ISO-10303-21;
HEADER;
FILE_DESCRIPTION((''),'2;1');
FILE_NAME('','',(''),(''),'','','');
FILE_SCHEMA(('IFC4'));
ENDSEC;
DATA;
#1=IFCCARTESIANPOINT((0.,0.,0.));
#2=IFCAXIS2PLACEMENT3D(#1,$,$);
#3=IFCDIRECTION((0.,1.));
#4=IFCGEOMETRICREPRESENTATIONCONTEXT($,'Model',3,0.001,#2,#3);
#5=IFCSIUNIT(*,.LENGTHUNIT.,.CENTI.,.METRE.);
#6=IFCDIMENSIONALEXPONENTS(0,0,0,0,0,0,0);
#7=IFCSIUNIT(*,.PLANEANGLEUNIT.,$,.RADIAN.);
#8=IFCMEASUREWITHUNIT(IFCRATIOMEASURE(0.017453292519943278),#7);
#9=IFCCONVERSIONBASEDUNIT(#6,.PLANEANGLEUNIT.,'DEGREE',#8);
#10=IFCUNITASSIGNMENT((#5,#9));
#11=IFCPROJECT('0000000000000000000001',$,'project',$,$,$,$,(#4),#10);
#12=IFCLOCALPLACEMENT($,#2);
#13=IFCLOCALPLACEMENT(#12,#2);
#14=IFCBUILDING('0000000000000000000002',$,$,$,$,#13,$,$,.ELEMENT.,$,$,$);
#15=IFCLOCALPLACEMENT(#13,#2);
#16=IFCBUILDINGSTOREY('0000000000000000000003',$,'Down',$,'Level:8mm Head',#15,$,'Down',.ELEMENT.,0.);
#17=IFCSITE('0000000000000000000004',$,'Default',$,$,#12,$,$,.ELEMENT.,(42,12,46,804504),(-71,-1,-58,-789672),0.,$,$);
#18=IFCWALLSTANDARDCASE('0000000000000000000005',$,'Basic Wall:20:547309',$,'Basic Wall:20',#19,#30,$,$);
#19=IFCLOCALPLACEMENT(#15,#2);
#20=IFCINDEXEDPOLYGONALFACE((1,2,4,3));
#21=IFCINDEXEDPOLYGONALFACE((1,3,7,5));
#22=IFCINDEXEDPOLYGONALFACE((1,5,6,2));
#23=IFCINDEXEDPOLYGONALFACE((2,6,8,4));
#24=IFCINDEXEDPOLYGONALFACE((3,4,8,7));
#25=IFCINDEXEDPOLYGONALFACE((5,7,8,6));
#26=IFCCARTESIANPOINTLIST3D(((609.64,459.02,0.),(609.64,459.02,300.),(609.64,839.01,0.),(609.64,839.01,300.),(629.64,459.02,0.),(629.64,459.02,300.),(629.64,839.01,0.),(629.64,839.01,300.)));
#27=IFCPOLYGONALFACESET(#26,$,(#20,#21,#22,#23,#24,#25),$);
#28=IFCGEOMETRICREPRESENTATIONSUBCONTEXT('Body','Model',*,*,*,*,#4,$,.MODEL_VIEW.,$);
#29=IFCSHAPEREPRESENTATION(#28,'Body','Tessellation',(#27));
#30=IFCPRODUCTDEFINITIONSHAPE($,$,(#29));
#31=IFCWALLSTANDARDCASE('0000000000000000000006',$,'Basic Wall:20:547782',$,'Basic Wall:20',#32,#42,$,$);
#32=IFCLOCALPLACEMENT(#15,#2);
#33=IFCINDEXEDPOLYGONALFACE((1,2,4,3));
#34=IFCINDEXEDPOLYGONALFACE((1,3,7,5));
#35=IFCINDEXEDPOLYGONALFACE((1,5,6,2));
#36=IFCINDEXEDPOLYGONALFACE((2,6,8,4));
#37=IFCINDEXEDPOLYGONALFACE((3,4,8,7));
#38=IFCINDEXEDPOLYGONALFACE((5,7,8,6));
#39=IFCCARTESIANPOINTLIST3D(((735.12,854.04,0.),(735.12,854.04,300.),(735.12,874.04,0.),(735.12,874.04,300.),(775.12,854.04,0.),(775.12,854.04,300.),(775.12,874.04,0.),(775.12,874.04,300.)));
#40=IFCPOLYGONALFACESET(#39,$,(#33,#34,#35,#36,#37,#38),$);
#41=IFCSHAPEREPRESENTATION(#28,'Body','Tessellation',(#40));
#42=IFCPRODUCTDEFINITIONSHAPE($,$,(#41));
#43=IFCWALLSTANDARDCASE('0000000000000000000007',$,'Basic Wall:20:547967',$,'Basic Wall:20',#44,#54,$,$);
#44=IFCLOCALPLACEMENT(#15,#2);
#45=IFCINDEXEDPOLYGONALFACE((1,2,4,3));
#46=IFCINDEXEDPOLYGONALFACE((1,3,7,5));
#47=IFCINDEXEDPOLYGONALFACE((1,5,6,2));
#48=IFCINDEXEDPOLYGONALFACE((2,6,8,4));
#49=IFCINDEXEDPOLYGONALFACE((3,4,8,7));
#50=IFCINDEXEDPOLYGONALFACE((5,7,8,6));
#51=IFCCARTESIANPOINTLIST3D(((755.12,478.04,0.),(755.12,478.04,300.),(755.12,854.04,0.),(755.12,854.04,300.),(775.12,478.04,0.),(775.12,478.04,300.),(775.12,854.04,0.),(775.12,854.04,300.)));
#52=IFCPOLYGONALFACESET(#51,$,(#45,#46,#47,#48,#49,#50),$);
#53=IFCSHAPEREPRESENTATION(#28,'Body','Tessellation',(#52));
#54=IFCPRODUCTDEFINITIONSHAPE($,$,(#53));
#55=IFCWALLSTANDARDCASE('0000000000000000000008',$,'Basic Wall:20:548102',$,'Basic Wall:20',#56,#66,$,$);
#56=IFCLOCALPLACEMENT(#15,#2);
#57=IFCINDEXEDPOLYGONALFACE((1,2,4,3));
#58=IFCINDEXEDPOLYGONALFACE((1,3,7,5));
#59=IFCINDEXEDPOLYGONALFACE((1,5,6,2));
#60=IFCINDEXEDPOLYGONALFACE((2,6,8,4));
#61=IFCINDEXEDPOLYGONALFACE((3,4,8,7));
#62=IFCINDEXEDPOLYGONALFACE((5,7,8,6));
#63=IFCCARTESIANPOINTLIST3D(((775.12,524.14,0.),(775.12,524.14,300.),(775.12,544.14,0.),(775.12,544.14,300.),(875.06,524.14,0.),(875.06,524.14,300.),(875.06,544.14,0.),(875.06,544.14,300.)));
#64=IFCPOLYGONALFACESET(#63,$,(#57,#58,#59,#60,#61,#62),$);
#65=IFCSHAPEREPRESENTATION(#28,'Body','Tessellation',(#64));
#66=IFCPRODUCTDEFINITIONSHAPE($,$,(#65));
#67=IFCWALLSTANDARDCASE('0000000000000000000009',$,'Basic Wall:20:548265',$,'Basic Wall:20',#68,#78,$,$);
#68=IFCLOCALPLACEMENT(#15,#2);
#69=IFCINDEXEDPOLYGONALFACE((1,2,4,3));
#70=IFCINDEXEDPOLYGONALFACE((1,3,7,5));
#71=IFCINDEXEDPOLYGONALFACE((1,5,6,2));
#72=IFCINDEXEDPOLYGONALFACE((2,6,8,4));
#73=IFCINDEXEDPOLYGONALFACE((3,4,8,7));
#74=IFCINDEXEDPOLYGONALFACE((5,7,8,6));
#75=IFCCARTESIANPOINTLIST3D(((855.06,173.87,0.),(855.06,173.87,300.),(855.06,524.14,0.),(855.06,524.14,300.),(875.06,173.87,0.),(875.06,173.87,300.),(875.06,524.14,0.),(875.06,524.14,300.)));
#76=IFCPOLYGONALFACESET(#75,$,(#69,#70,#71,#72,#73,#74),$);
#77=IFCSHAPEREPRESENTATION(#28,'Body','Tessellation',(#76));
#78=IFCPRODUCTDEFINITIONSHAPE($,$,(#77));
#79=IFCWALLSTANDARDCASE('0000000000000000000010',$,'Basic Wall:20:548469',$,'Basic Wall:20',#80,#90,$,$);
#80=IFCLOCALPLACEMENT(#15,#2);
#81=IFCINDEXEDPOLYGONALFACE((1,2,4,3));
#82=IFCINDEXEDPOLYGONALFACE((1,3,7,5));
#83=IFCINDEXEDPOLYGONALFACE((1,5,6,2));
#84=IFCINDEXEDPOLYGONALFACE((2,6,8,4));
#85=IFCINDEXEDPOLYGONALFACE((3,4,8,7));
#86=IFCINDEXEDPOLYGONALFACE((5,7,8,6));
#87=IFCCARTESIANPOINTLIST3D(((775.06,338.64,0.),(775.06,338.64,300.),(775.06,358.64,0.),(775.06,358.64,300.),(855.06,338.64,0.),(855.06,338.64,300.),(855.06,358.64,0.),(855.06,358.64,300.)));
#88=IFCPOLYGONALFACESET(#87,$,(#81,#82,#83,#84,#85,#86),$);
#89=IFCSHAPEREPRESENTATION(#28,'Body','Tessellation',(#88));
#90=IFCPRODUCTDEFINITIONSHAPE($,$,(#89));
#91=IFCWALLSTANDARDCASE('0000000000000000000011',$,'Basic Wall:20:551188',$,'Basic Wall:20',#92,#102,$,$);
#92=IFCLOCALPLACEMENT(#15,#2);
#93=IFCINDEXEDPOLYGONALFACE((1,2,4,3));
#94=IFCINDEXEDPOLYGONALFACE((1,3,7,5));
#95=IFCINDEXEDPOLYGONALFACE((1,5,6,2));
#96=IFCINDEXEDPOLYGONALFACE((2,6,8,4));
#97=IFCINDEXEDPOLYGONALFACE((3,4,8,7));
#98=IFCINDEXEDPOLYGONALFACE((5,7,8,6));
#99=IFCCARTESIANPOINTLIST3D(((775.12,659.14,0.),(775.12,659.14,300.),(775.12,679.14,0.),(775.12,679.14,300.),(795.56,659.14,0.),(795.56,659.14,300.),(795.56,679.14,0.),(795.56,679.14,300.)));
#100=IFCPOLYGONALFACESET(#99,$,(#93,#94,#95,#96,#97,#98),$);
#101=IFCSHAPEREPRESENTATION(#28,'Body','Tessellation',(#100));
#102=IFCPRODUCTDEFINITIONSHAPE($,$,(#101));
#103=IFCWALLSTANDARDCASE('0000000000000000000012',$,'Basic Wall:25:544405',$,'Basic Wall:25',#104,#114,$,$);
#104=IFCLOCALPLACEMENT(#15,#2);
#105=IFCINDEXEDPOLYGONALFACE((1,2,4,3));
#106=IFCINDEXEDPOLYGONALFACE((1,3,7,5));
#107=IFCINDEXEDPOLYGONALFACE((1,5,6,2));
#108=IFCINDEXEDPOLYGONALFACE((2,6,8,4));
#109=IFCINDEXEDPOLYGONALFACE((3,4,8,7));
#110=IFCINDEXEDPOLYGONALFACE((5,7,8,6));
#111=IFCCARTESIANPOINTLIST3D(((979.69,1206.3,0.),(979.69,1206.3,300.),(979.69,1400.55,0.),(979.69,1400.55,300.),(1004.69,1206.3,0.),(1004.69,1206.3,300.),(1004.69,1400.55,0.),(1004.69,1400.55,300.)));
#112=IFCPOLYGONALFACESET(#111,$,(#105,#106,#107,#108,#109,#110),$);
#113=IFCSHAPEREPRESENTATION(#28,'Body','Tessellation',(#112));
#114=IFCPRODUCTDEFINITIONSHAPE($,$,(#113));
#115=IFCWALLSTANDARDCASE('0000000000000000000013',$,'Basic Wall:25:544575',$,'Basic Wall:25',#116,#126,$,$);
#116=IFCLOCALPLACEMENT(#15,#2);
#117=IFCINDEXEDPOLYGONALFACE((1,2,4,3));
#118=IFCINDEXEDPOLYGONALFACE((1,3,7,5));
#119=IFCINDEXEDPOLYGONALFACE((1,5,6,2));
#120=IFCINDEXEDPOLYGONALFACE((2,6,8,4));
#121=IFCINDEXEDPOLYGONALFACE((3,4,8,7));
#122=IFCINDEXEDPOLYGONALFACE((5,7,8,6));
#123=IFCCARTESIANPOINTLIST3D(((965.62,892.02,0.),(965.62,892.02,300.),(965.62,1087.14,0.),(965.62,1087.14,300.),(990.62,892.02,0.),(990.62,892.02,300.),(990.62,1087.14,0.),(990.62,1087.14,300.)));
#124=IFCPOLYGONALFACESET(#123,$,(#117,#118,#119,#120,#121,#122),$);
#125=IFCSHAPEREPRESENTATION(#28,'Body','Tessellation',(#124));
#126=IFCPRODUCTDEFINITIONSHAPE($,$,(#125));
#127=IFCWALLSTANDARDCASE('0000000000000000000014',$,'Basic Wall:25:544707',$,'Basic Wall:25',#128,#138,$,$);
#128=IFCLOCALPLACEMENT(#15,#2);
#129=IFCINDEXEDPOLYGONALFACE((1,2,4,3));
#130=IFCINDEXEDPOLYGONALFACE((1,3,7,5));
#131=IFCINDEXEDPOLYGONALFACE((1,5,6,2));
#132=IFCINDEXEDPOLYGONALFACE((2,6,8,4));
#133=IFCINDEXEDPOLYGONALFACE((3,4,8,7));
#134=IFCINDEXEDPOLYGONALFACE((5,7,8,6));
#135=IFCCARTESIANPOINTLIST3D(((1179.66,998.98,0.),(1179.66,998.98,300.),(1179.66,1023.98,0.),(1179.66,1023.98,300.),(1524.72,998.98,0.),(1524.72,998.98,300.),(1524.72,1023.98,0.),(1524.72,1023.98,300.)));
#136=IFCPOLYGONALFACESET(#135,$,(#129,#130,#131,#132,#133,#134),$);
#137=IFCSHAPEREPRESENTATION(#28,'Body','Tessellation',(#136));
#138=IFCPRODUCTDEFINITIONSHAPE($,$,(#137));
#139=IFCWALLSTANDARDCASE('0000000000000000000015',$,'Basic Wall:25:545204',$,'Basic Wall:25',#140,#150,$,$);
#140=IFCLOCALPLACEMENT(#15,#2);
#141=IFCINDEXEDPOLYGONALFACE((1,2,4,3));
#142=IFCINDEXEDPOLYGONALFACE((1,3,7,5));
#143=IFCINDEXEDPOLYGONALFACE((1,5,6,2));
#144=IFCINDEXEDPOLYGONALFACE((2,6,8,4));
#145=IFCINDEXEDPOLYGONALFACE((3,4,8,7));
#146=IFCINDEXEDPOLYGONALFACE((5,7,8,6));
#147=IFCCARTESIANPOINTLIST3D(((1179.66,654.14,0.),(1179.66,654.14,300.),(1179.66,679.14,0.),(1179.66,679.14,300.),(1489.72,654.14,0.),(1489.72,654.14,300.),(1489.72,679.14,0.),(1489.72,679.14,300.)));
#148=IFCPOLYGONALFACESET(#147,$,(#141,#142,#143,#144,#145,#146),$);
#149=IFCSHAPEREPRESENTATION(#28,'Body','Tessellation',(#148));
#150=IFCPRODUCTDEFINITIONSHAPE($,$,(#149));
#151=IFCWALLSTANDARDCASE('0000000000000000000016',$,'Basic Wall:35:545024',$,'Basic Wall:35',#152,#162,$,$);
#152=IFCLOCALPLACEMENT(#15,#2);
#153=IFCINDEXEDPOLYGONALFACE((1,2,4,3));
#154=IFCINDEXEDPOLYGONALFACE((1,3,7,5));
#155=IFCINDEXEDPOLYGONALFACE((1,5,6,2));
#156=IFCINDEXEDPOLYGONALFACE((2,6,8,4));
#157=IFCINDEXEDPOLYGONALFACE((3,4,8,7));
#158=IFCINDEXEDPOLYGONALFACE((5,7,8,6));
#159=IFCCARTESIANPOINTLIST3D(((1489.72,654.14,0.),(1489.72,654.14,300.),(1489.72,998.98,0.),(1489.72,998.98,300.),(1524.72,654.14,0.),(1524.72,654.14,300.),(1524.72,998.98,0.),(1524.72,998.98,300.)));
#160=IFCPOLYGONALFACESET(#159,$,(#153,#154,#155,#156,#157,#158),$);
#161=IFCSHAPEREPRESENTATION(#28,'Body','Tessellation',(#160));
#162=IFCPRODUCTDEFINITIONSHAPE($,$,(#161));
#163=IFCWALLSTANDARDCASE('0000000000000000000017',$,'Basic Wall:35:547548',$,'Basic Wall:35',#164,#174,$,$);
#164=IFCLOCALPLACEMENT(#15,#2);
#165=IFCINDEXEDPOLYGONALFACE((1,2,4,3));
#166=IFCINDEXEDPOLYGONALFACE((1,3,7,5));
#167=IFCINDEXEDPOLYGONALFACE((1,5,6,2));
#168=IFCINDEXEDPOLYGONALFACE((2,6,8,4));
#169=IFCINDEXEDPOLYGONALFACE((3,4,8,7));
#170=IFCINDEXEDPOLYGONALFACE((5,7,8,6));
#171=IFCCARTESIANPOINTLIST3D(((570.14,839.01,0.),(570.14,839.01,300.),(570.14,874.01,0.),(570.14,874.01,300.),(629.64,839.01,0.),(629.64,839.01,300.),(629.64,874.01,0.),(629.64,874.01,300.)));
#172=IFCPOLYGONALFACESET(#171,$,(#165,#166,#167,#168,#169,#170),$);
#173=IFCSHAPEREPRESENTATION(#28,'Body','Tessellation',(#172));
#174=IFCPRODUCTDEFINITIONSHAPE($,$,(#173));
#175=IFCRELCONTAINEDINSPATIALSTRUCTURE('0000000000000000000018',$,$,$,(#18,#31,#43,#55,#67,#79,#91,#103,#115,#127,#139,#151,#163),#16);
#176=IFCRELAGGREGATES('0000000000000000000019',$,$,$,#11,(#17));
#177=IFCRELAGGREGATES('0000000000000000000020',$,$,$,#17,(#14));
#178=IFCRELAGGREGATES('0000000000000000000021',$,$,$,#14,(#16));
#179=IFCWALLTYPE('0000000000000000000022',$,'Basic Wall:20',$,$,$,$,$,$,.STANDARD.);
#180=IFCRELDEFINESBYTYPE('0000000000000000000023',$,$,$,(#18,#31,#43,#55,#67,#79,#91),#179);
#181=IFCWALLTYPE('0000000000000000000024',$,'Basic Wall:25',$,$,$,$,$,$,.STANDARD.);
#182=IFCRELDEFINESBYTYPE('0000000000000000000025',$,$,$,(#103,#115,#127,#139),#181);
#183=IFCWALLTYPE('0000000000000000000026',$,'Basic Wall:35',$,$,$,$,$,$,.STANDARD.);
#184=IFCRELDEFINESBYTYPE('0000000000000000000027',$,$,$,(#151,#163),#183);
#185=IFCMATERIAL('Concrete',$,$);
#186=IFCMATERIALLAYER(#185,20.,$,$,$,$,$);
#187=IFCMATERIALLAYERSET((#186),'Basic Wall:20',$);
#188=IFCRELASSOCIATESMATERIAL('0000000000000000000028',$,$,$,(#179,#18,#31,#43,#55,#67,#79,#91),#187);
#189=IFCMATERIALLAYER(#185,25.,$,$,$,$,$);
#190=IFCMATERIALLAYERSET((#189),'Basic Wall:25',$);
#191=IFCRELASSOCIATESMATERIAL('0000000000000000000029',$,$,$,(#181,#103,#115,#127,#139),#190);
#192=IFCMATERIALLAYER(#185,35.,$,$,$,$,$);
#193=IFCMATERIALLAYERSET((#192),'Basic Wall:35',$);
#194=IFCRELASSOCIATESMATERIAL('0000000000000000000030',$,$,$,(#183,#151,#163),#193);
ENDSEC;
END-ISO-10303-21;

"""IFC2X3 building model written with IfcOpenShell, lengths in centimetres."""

from ifc_helpers import new_model, entity, si_unit, converted_unit, direction, frame, frame_2d, origin, place, context, subcontext, project, spatial, rectangle, extrude, material, layer, layer_set, layer_usage, type_object, element, save


model = new_model("IFC2X3")

# Units and contexts
model_context = context("Model", 3, precision=0.001, world=origin(), true_north=direction((0.0, 1.0)))
body_context = subcontext(model_context, "Body", "Model", "MODEL_VIEW")
ifc_project = project(units=[si_unit("LENGTHUNIT", "METRE", prefix="CENTI"), converted_unit("PLANEANGLEUNIT", "DEGREE", entity("IfcRatioMeasure", 0.017453292519943278), si_unit("PLANEANGLEUNIT", "RADIAN"), dimensions=[0, 0, 0, 0, 0, 0, 0])], contexts=[model_context])

# Site, building, storey
site_placement = place(None, origin())
site = spatial("IfcSite", under=ifc_project, at=site_placement, Name="Default", CompositionType="ELEMENT", RefLatitude=(42, 12, 46, 804504), RefLongitude=(-71, -1, -58, -789672), RefElevation=0.0)
building_placement = place(site_placement, origin())
building = spatial("IfcBuilding", under=site, at=building_placement, CompositionType="ELEMENT")
storey_placement = place(building_placement, origin())
storey = spatial("IfcBuildingStorey", under=building, at=storey_placement, Name="Down", ObjectType="Level:8mm Head", LongName="Down", CompositionType="ELEMENT", Elevation=0.0)

# Walls
ifc_material = material(Name="Concrete")
ifc_layer_1 = layer(ifc_material, 20.0)
ifc_layer_set_1 = layer_set([ifc_layer_1], Name="Basic Wall:20")
wall_type_1 = type_object("IfcWallType", Name="Basic Wall:20", PredefinedType="STANDARD", material=ifc_layer_set_1)
ifc_layer_usage_1 = layer_usage(ifc_layer_set_1, "AXIS2", "POSITIVE", -10.0)
wall_1_placement = place(storey_placement, frame((619.64, 459.02, 0.0), z_axis=(0.0, 0.0, 1.0), x_axis=(0.0, 1.0, 0.0)))
element("IfcWallStandardCase", 1, at=wall_1_placement, inside=storey, type_object=wall_type_1, material=ifc_layer_usage_1, Name="Basic Wall:20:547309", ObjectType="Basic Wall:20", context=body_context, shape_type="SweptSolid", body=[
    extrude(rectangle(XDim=379.98, YDim=20.0, at=frame_2d((189.99, 0.0), x_axis=(-1.0, 0.0))), origin(), (0.0, 0.0, 1.0), 300.0),
])
ifc_layer_usage_2 = layer_usage(ifc_layer_set_1, "AXIS2", "POSITIVE", -10.0)
wall_2_placement = place(storey_placement, frame((735.12, 864.04, 0.0)))
element("IfcWallStandardCase", 2, at=wall_2_placement, inside=storey, type_object=wall_type_1, material=ifc_layer_usage_2, Name="Basic Wall:20:547782", ObjectType="Basic Wall:20", context=body_context, shape_type="SweptSolid", body=[
    extrude(rectangle(XDim=40.0, YDim=20.0, at=frame_2d((20.0, 0.0), x_axis=(-1.0, 0.0))), origin(), (0.0, 0.0, 1.0), 300.0),
])
ifc_layer_usage_3 = layer_usage(ifc_layer_set_1, "AXIS2", "NEGATIVE", 10.0)
wall_3_placement = place(storey_placement, frame((765.12, 854.04, 0.0), z_axis=(0.0, 0.0, 1.0), x_axis=(0.0, -1.0, 0.0)))
element("IfcWallStandardCase", 3, at=wall_3_placement, inside=storey, type_object=wall_type_1, material=ifc_layer_usage_3, Name="Basic Wall:20:547967", ObjectType="Basic Wall:20", context=body_context, shape_type="SweptSolid", body=[
    extrude(rectangle(XDim=376.0, YDim=20.0, at=frame_2d((188.0, 0.0), x_axis=(-1.0, 0.0))), origin(), (0.0, 0.0, 1.0), 300.0),
])
ifc_layer_usage_4 = layer_usage(ifc_layer_set_1, "AXIS2", "POSITIVE", -10.0)
wall_4_placement = place(storey_placement, frame((775.12, 534.14, 0.0)))
element("IfcWallStandardCase", 4, at=wall_4_placement, inside=storey, type_object=wall_type_1, material=ifc_layer_usage_4, Name="Basic Wall:20:548102", ObjectType="Basic Wall:20", context=body_context, shape_type="SweptSolid", body=[
    extrude(rectangle(XDim=99.94, YDim=20.0, at=frame_2d((49.97, 0.0), x_axis=(-1.0, 0.0))), origin(), (0.0, 0.0, 1.0), 300.0),
])
ifc_layer_usage_5 = layer_usage(ifc_layer_set_1, "AXIS2", "NEGATIVE", 10.0)
wall_5_placement = place(storey_placement, frame((865.06, 524.14, 0.0), z_axis=(0.0, 0.0, 1.0), x_axis=(0.0, -1.0, 0.0)))
element("IfcWallStandardCase", 5, at=wall_5_placement, inside=storey, type_object=wall_type_1, material=ifc_layer_usage_5, Name="Basic Wall:20:548265", ObjectType="Basic Wall:20", context=body_context, shape_type="SweptSolid", body=[
    extrude(rectangle(XDim=350.27, YDim=20.0, at=frame_2d((175.14, 0.0), x_axis=(-1.0, 0.0))), origin(), (0.0, 0.0, 1.0), 300.0),
])
ifc_layer_usage_6 = layer_usage(ifc_layer_set_1, "AXIS2", "NEGATIVE", 10.0)
wall_6_placement = place(storey_placement, frame((855.06, 348.64, 0.0), z_axis=(0.0, 0.0, 1.0), x_axis=(-1.0, 0.0, 0.0)))
element("IfcWallStandardCase", 6, at=wall_6_placement, inside=storey, type_object=wall_type_1, material=ifc_layer_usage_6, Name="Basic Wall:20:548469", ObjectType="Basic Wall:20", context=body_context, shape_type="SweptSolid", body=[
    extrude(rectangle(XDim=80.0, YDim=20.0, at=frame_2d((40.0, 0.0), x_axis=(-1.0, 0.0))), origin(), (0.0, 0.0, 1.0), 300.0),
])
ifc_layer_usage_7 = layer_usage(ifc_layer_set_1, "AXIS2", "POSITIVE", -10.0)
wall_7_placement = place(storey_placement, frame((775.12, 669.14, 0.0)))
element("IfcWallStandardCase", 7, at=wall_7_placement, inside=storey, type_object=wall_type_1, material=ifc_layer_usage_7, Name="Basic Wall:20:551188", ObjectType="Basic Wall:20", context=body_context, shape_type="SweptSolid", body=[
    extrude(rectangle(XDim=20.44, YDim=20.0, at=frame_2d((10.22, 0.0), x_axis=(-1.0, 0.0))), origin(), (0.0, 0.0, 1.0), 300.0),
])
ifc_layer_2 = layer(ifc_material, 25.0)
ifc_layer_set_2 = layer_set([ifc_layer_2], Name="Basic Wall:25")
ifc_layer_usage_8 = layer_usage(ifc_layer_set_2, "AXIS2", "NEGATIVE", 12.5)
wall_type_2 = type_object("IfcWallType", Name="Basic Wall:25", PredefinedType="STANDARD", material=ifc_layer_set_2)
wall_8_placement = place(storey_placement, frame((992.19, 1400.55, 0.0), z_axis=(0.0, 0.0, 1.0), x_axis=(0.0, -1.0, 0.0)))
element("IfcWallStandardCase", 8, at=wall_8_placement, inside=storey, type_object=wall_type_2, material=ifc_layer_usage_8, Name="Basic Wall:25:544405", ObjectType="Basic Wall:25", context=body_context, shape_type="SweptSolid", body=[
    extrude(rectangle(XDim=194.25, YDim=25.0, at=frame_2d((97.13, 0.0), x_axis=(-1.0, 0.0))), origin(), (0.0, 0.0, 1.0), 300.0),
])
ifc_layer_usage_9 = layer_usage(ifc_layer_set_2, "AXIS2", "POSITIVE", -12.5)
wall_9_placement = place(storey_placement, frame((978.12, 1087.14, 0.0), z_axis=(0.0, 0.0, 1.0), x_axis=(0.0, -1.0, 0.0)))
element("IfcWallStandardCase", 9, at=wall_9_placement, inside=storey, type_object=wall_type_2, material=ifc_layer_usage_9, Name="Basic Wall:25:544575", ObjectType="Basic Wall:25", context=body_context, shape_type="SweptSolid", body=[
    extrude(rectangle(XDim=195.12, YDim=25.0, at=frame_2d((97.56, 0.0), x_axis=(-1.0, 0.0))), origin(), (0.0, 0.0, 1.0), 300.0),
])
ifc_layer_usage_10 = layer_usage(ifc_layer_set_2, "AXIS2", "NEGATIVE", 12.5)
wall_10_placement = place(storey_placement, frame((1179.66, 1011.48, 0.0)))
element("IfcWallStandardCase", 10, at=wall_10_placement, inside=storey, type_object=wall_type_2, material=ifc_layer_usage_10, Name="Basic Wall:25:544707", ObjectType="Basic Wall:25", context=body_context, shape_type="SweptSolid", body=[
    extrude(rectangle(XDim=345.06, YDim=25.0, at=frame_2d((172.53, 0.0), x_axis=(-1.0, 0.0))), origin(), (0.0, 0.0, 1.0), 300.0),
])
ifc_layer_usage_11 = layer_usage(ifc_layer_set_2, "AXIS2", "NEGATIVE", 12.5)
wall_11_placement = place(storey_placement, frame((1489.72, 666.64, 0.0), z_axis=(0.0, 0.0, 1.0), x_axis=(-1.0, 0.0, 0.0)))
element("IfcWallStandardCase", 11, at=wall_11_placement, inside=storey, type_object=wall_type_2, material=ifc_layer_usage_11, Name="Basic Wall:25:545204", ObjectType="Basic Wall:25", context=body_context, shape_type="SweptSolid", body=[
    extrude(rectangle(XDim=310.06, YDim=25.0, at=frame_2d((155.03, 0.0), x_axis=(-1.0, 0.0))), origin(), (0.0, 0.0, 1.0), 300.0),
])
ifc_layer_3 = layer(ifc_material, 35.0)
ifc_layer_set_3 = layer_set([ifc_layer_3], Name="Basic Wall:35")
ifc_layer_usage_12 = layer_usage(ifc_layer_set_3, "AXIS2", "NEGATIVE", 17.5)
wall_type_3 = type_object("IfcWallType", Name="Basic Wall:35", PredefinedType="STANDARD", material=ifc_layer_set_3)
wall_12_placement = place(storey_placement, frame((1507.22, 998.98, 0.0), z_axis=(0.0, 0.0, 1.0), x_axis=(0.0, -1.0, 0.0)))
element("IfcWallStandardCase", 12, at=wall_12_placement, inside=storey, type_object=wall_type_3, material=ifc_layer_usage_12, Name="Basic Wall:35:545024", ObjectType="Basic Wall:35", context=body_context, shape_type="SweptSolid", body=[
    extrude(rectangle(XDim=344.84, YDim=35.0, at=frame_2d((172.42, 0.0), x_axis=(-1.0, 0.0))), origin(), (0.0, 0.0, 1.0), 300.0),
])
ifc_layer_usage_13 = layer_usage(ifc_layer_set_3, "AXIS2", "POSITIVE", -17.5)
wall_13_placement = place(storey_placement, frame((629.64, 856.51, 0.0), z_axis=(0.0, 0.0, 1.0), x_axis=(-1.0, 0.0, 0.0)))
element("IfcWallStandardCase", 13, at=wall_13_placement, inside=storey, type_object=wall_type_3, material=ifc_layer_usage_13, Name="Basic Wall:35:547548", ObjectType="Basic Wall:35", context=body_context, shape_type="SweptSolid", body=[
    extrude(rectangle(XDim=59.5, YDim=35.0, at=frame_2d((29.75, 0.0), x_axis=(-1.0, 0.0))), origin(), (0.0, 0.0, 1.0), 300.0),
])

save(model, "model.ifc")
